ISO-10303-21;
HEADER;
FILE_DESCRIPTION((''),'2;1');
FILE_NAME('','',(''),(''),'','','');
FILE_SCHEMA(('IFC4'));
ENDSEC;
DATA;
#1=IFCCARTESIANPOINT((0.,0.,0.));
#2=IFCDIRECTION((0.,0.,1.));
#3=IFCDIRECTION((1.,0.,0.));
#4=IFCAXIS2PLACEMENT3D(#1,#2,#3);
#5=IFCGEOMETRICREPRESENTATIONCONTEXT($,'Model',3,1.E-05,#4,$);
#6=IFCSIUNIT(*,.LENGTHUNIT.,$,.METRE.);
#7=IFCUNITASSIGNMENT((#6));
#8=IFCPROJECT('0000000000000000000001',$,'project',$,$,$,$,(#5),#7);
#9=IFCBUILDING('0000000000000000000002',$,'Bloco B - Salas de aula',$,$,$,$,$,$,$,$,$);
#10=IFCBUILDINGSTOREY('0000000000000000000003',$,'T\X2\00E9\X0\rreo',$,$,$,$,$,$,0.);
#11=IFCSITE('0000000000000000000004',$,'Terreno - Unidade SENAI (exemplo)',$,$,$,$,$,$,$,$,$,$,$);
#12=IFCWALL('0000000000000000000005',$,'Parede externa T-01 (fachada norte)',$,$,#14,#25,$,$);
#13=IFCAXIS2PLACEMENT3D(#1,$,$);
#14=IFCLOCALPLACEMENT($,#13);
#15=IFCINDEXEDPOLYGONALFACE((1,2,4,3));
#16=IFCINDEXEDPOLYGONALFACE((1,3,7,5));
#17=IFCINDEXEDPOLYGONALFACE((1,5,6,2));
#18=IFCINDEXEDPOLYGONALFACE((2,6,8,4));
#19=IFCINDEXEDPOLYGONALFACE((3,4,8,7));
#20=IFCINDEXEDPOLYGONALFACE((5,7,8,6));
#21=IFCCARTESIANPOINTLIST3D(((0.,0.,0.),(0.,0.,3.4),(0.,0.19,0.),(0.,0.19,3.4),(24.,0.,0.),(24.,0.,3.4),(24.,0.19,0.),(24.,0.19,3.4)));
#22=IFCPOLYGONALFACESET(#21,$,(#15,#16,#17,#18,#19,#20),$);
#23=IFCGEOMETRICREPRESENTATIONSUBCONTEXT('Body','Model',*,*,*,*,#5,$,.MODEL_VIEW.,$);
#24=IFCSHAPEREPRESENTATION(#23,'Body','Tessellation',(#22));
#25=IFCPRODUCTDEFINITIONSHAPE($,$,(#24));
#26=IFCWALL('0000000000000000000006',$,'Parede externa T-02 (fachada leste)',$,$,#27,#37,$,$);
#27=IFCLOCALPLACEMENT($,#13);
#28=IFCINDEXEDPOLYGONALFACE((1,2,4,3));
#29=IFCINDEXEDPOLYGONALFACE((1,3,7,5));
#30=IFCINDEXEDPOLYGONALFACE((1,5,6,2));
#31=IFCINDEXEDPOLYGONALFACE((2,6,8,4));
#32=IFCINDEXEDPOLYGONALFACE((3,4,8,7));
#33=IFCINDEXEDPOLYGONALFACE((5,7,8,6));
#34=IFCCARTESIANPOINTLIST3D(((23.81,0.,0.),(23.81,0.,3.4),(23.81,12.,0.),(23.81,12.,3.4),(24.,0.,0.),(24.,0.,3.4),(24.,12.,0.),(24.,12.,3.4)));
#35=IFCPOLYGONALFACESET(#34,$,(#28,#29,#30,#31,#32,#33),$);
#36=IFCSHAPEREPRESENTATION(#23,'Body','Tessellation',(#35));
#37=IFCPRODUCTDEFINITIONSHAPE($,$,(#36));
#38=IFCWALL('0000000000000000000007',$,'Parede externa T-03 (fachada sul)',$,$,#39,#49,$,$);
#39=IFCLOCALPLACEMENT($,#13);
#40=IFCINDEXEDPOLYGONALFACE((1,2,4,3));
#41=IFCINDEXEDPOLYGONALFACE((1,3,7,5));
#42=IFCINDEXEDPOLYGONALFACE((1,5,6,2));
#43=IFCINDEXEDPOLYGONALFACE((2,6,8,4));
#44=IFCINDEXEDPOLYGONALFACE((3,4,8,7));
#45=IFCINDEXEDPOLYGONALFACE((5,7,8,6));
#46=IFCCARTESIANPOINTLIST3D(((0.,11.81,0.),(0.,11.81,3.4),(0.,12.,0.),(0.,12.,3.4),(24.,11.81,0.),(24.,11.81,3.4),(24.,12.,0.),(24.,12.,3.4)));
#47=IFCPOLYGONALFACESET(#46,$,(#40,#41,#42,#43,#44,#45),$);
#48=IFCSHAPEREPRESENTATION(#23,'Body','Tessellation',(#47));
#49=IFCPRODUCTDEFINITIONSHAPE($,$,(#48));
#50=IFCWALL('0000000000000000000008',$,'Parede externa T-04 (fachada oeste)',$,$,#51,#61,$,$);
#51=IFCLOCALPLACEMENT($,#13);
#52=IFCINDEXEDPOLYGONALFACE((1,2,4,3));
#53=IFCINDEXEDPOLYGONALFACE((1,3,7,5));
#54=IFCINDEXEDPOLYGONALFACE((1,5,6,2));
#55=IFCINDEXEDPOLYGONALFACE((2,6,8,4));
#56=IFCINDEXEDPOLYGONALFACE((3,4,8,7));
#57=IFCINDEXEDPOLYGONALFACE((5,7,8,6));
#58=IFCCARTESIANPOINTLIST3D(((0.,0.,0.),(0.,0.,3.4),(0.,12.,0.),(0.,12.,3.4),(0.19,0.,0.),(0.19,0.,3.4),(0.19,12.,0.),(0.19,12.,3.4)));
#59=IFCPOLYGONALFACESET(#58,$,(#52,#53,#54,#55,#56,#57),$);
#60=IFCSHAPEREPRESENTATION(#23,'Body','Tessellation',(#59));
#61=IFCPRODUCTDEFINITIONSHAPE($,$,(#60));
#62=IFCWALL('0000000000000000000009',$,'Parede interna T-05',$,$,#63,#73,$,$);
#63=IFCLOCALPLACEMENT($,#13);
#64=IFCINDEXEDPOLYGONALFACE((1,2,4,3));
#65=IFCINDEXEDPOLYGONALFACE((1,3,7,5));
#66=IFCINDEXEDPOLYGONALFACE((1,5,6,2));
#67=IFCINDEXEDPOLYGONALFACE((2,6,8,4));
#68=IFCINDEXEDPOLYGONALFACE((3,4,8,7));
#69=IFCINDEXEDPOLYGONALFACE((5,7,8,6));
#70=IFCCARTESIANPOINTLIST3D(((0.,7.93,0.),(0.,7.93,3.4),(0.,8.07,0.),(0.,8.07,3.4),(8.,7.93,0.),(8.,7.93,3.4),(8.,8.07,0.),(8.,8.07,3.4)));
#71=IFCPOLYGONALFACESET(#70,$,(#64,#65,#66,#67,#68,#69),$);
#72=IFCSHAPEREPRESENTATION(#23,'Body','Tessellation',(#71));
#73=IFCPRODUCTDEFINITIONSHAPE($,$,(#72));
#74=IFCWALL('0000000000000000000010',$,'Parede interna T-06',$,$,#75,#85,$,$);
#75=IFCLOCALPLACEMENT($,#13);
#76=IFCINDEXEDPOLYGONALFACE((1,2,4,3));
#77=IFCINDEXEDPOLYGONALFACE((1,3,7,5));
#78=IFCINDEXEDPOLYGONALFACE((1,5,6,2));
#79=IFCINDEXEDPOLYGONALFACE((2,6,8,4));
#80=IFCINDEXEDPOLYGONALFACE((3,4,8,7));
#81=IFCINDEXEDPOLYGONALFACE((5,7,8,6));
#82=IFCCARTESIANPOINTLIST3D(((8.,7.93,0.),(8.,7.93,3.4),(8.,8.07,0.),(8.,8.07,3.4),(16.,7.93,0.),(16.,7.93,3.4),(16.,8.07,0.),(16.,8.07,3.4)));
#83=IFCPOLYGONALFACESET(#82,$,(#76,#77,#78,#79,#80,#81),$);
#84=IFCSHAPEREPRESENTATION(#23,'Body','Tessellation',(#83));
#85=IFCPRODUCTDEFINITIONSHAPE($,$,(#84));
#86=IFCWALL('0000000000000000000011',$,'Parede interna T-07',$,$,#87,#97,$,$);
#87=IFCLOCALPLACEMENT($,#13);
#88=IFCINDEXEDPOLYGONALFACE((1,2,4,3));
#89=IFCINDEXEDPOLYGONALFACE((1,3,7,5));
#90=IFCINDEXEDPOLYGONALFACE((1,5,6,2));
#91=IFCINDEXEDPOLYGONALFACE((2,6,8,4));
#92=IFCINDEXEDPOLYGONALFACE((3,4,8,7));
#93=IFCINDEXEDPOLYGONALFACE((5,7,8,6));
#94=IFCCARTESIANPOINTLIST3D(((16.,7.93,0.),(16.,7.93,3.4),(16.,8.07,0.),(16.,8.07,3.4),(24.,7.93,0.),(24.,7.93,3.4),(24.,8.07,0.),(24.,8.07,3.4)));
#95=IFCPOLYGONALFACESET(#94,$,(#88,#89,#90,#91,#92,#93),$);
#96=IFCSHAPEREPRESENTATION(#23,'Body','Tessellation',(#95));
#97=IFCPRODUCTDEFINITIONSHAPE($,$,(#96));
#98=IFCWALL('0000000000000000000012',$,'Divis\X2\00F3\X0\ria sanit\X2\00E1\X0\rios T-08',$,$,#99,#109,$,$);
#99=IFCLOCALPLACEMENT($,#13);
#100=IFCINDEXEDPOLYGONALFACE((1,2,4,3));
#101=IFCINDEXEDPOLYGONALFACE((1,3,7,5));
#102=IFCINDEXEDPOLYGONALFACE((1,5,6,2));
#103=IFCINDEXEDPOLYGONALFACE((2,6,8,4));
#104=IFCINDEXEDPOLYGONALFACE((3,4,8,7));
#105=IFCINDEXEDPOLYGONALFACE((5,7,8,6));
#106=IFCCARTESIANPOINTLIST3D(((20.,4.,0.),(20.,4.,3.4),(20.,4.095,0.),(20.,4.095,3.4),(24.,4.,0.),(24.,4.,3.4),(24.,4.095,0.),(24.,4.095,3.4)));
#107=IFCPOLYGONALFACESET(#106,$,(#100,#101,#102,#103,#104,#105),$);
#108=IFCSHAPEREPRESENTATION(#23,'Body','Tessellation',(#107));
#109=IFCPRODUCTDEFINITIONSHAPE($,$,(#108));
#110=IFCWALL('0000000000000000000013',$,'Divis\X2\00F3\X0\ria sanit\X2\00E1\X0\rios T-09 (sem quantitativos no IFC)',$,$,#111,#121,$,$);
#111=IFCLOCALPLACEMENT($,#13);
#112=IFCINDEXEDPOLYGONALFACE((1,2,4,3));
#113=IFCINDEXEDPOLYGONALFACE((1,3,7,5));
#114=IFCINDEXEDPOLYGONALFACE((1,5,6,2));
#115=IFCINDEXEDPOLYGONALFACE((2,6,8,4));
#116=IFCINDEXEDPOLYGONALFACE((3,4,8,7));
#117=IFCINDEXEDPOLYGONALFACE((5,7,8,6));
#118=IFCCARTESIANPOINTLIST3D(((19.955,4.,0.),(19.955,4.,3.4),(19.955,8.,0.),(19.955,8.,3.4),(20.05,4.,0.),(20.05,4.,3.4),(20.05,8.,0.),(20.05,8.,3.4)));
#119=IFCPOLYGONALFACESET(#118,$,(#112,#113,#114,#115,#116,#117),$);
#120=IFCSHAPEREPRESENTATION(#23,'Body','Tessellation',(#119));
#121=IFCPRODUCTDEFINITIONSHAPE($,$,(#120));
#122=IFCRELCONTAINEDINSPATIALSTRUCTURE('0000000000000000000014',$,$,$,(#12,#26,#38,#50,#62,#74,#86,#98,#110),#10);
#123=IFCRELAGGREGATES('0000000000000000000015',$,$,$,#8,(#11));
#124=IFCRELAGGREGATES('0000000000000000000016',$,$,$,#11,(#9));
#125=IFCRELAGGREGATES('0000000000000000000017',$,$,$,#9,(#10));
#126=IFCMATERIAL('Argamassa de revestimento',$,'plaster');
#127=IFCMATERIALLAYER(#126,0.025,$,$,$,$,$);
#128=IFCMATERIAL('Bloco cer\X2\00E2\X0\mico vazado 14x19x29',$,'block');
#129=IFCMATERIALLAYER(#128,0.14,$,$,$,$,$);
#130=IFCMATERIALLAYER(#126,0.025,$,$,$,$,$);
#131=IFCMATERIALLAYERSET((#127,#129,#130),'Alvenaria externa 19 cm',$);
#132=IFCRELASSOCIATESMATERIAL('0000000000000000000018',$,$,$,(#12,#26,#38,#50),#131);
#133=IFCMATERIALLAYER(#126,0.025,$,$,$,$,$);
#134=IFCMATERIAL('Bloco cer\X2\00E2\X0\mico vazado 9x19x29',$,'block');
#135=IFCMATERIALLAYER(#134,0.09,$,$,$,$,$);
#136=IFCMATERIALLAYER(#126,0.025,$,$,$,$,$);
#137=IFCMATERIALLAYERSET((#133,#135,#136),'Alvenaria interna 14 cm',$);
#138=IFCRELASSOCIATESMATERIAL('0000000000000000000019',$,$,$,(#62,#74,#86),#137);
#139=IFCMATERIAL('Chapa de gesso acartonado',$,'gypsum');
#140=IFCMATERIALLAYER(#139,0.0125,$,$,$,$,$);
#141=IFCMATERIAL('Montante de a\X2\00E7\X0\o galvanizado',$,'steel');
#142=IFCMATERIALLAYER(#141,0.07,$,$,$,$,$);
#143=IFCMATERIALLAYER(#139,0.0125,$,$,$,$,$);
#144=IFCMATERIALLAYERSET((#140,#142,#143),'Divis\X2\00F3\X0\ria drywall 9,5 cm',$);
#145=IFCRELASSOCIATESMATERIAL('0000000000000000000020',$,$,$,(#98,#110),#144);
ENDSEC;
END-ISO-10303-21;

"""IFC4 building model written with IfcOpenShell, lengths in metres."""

from ifc_helpers import new_model, si_unit, frame, origin_with_axes, place, context, subcontext, project, spatial, indexed_curve, outline, extrude, material, layer, layer_set, layer_usage, element, save


model = new_model("IFC4")

# Units and contexts
model_context = context("Model", 3, precision=1e-05, world=origin_with_axes())
body_context = subcontext(model_context, "Body", "Model", "MODEL_VIEW")
ifc_project = project(units=[si_unit("LENGTHUNIT", "METRE")], contexts=[model_context])

# Site, building, storey
site = spatial("IfcSite", under=ifc_project, Name="Terreno - Unidade SENAI (exemplo)")
building = spatial("IfcBuilding", under=site, Name="Bloco B - Salas de aula")
storey = spatial("IfcBuildingStorey", under=building, Name="Térreo", Elevation=0.0)

# Walls
ifc_material_1 = material(Name="Argamassa de revestimento", Category="plaster")
ifc_layer_1 = layer(ifc_material_1, 0.025)
ifc_material_2 = material(Name="Bloco cerâmico vazado 14x19x29", Category="block")
ifc_layer_2 = layer(ifc_material_2, 0.14)
ifc_layer_3 = layer(ifc_material_1, 0.025)
ifc_layer_set_1 = layer_set([ifc_layer_1, ifc_layer_2, ifc_layer_3], Name="Alvenaria externa 19 cm")
ifc_layer_usage_1 = layer_usage(ifc_layer_set_1, "AXIS2", "POSITIVE", 0.0)
wall_1_placement = place(None, origin_with_axes())
element("IfcWall", 1, at=wall_1_placement, inside=storey, material=ifc_layer_usage_1, Name="Parede externa T-01 (fachada norte)", context=body_context, shape_type="SweptSolid", body=[
    extrude(outline(indexed_curve([(0.0, 0.0), (0.0, 0.19), (24.0, 0.19), (24.0, 0.0), (0.0, 0.0)], self_intersect=False)), origin_with_axes(), (0.0, 0.0, 1.0), 3.4),
])
ifc_layer_usage_2 = layer_usage(ifc_layer_set_1, "AXIS2", "POSITIVE", 0.0)
wall_2_placement = place(None, frame((24.0, 0.0, 0.0), z_axis=(0.0, 0.0, 1.0), x_axis=(0.0, 1.0, 0.0)))
element("IfcWall", 2, at=wall_2_placement, inside=storey, material=ifc_layer_usage_2, Name="Parede externa T-02 (fachada leste)", context=body_context, shape_type="SweptSolid", body=[
    extrude(outline(indexed_curve([(0.0, 0.0), (0.0, 0.19), (12.0, 0.19), (12.0, 0.0), (0.0, 0.0)], self_intersect=False)), origin_with_axes(), (0.0, 0.0, 1.0), 3.4),
])
ifc_layer_usage_3 = layer_usage(ifc_layer_set_1, "AXIS2", "POSITIVE", 0.0)
wall_3_placement = place(None, frame((0.0, 11.81, 0.0), z_axis=(0.0, 0.0, 1.0), x_axis=(1.0, 0.0, 0.0)))
element("IfcWall", 3, at=wall_3_placement, inside=storey, material=ifc_layer_usage_3, Name="Parede externa T-03 (fachada sul)", context=body_context, shape_type="SweptSolid", body=[
    extrude(outline(indexed_curve([(0.0, 0.0), (0.0, 0.19), (24.0, 0.19), (24.0, 0.0), (0.0, 0.0)], self_intersect=False)), origin_with_axes(), (0.0, 0.0, 1.0), 3.4),
])
ifc_layer_usage_4 = layer_usage(ifc_layer_set_1, "AXIS2", "POSITIVE", 0.0)
wall_4_placement = place(None, frame((0.19, 0.0, 0.0), z_axis=(0.0, 0.0, 1.0), x_axis=(0.0, 1.0, 0.0)))
element("IfcWall", 4, at=wall_4_placement, inside=storey, material=ifc_layer_usage_4, Name="Parede externa T-04 (fachada oeste)", context=body_context, shape_type="SweptSolid", body=[
    extrude(outline(indexed_curve([(0.0, 0.0), (0.0, 0.19), (12.0, 0.19), (12.0, 0.0), (0.0, 0.0)], self_intersect=False)), origin_with_axes(), (0.0, 0.0, 1.0), 3.4),
])
ifc_layer_4 = layer(ifc_material_1, 0.025)
ifc_material_3 = material(Name="Bloco cerâmico vazado 9x19x29", Category="block")
ifc_layer_5 = layer(ifc_material_3, 0.09)
ifc_layer_6 = layer(ifc_material_1, 0.025)
ifc_layer_set_2 = layer_set([ifc_layer_4, ifc_layer_5, ifc_layer_6], Name="Alvenaria interna 14 cm")
ifc_layer_usage_5 = layer_usage(ifc_layer_set_2, "AXIS2", "POSITIVE", 0.0)
wall_5_placement = place(None, frame((0.0, 7.93, 0.0), z_axis=(0.0, 0.0, 1.0), x_axis=(1.0, 0.0, 0.0)))
element("IfcWall", 5, at=wall_5_placement, inside=storey, material=ifc_layer_usage_5, Name="Parede interna T-05", context=body_context, shape_type="SweptSolid", body=[
    extrude(outline(indexed_curve([(0.0, 0.0), (0.0, 0.14), (8.0, 0.14), (8.0, 0.0), (0.0, 0.0)], self_intersect=False)), origin_with_axes(), (0.0, 0.0, 1.0), 3.4),
])
ifc_layer_usage_6 = layer_usage(ifc_layer_set_2, "AXIS2", "POSITIVE", 0.0)
wall_6_placement = place(None, frame((8.0, 7.93, 0.0), z_axis=(0.0, 0.0, 1.0), x_axis=(1.0, 0.0, 0.0)))
element("IfcWall", 6, at=wall_6_placement, inside=storey, material=ifc_layer_usage_6, Name="Parede interna T-06", context=body_context, shape_type="SweptSolid", body=[
    extrude(outline(indexed_curve([(0.0, 0.0), (0.0, 0.14), (8.0, 0.14), (8.0, 0.0), (0.0, 0.0)], self_intersect=False)), origin_with_axes(), (0.0, 0.0, 1.0), 3.4),
])
ifc_layer_usage_7 = layer_usage(ifc_layer_set_2, "AXIS2", "POSITIVE", 0.0)
wall_7_placement = place(None, frame((16.0, 7.93, 0.0), z_axis=(0.0, 0.0, 1.0), x_axis=(1.0, 0.0, 0.0)))
element("IfcWall", 7, at=wall_7_placement, inside=storey, material=ifc_layer_usage_7, Name="Parede interna T-07", context=body_context, shape_type="SweptSolid", body=[
    extrude(outline(indexed_curve([(0.0, 0.0), (0.0, 0.14), (8.0, 0.14), (8.0, 0.0), (0.0, 0.0)], self_intersect=False)), origin_with_axes(), (0.0, 0.0, 1.0), 3.4),
])
ifc_material_4 = material(Name="Chapa de gesso acartonado", Category="gypsum")
ifc_layer_7 = layer(ifc_material_4, 0.0125)
ifc_material_5 = material(Name="Montante de aço galvanizado", Category="steel")
ifc_layer_8 = layer(ifc_material_5, 0.07)
ifc_layer_9 = layer(ifc_material_4, 0.0125)
ifc_layer_set_3 = layer_set([ifc_layer_7, ifc_layer_8, ifc_layer_9], Name="Divisória drywall 9,5 cm")
ifc_layer_usage_8 = layer_usage(ifc_layer_set_3, "AXIS2", "POSITIVE", 0.0)
wall_8_placement = place(None, frame((20.0, 4.0, 0.0), z_axis=(0.0, 0.0, 1.0), x_axis=(1.0, 0.0, 0.0)))
element("IfcWall", 8, at=wall_8_placement, inside=storey, material=ifc_layer_usage_8, Name="Divisória sanitários T-08", context=body_context, shape_type="SweptSolid", body=[
    extrude(outline(indexed_curve([(0.0, 0.0), (0.0, 0.095), (4.0, 0.095), (4.0, 0.0), (0.0, 0.0)], self_intersect=False)), origin_with_axes(), (0.0, 0.0, 1.0), 3.4),
])
ifc_layer_usage_9 = layer_usage(ifc_layer_set_3, "AXIS2", "POSITIVE", 0.0)
wall_9_placement = place(None, frame((20.05, 4.0, 0.0), z_axis=(0.0, 0.0, 1.0), x_axis=(0.0, 1.0, 0.0)))
element("IfcWall", 9, at=wall_9_placement, inside=storey, material=ifc_layer_usage_9, Name="Divisória sanitários T-09 (sem quantitativos no IFC)", context=body_context, shape_type="SweptSolid", body=[
    extrude(outline(indexed_curve([(0.0, 0.0), (0.0, 0.095), (4.0, 0.095), (4.0, 0.0), (0.0, 0.0)], self_intersect=False)), origin_with_axes(), (0.0, 0.0, 1.0), 3.4),
])

save(model, "model.ifc")
